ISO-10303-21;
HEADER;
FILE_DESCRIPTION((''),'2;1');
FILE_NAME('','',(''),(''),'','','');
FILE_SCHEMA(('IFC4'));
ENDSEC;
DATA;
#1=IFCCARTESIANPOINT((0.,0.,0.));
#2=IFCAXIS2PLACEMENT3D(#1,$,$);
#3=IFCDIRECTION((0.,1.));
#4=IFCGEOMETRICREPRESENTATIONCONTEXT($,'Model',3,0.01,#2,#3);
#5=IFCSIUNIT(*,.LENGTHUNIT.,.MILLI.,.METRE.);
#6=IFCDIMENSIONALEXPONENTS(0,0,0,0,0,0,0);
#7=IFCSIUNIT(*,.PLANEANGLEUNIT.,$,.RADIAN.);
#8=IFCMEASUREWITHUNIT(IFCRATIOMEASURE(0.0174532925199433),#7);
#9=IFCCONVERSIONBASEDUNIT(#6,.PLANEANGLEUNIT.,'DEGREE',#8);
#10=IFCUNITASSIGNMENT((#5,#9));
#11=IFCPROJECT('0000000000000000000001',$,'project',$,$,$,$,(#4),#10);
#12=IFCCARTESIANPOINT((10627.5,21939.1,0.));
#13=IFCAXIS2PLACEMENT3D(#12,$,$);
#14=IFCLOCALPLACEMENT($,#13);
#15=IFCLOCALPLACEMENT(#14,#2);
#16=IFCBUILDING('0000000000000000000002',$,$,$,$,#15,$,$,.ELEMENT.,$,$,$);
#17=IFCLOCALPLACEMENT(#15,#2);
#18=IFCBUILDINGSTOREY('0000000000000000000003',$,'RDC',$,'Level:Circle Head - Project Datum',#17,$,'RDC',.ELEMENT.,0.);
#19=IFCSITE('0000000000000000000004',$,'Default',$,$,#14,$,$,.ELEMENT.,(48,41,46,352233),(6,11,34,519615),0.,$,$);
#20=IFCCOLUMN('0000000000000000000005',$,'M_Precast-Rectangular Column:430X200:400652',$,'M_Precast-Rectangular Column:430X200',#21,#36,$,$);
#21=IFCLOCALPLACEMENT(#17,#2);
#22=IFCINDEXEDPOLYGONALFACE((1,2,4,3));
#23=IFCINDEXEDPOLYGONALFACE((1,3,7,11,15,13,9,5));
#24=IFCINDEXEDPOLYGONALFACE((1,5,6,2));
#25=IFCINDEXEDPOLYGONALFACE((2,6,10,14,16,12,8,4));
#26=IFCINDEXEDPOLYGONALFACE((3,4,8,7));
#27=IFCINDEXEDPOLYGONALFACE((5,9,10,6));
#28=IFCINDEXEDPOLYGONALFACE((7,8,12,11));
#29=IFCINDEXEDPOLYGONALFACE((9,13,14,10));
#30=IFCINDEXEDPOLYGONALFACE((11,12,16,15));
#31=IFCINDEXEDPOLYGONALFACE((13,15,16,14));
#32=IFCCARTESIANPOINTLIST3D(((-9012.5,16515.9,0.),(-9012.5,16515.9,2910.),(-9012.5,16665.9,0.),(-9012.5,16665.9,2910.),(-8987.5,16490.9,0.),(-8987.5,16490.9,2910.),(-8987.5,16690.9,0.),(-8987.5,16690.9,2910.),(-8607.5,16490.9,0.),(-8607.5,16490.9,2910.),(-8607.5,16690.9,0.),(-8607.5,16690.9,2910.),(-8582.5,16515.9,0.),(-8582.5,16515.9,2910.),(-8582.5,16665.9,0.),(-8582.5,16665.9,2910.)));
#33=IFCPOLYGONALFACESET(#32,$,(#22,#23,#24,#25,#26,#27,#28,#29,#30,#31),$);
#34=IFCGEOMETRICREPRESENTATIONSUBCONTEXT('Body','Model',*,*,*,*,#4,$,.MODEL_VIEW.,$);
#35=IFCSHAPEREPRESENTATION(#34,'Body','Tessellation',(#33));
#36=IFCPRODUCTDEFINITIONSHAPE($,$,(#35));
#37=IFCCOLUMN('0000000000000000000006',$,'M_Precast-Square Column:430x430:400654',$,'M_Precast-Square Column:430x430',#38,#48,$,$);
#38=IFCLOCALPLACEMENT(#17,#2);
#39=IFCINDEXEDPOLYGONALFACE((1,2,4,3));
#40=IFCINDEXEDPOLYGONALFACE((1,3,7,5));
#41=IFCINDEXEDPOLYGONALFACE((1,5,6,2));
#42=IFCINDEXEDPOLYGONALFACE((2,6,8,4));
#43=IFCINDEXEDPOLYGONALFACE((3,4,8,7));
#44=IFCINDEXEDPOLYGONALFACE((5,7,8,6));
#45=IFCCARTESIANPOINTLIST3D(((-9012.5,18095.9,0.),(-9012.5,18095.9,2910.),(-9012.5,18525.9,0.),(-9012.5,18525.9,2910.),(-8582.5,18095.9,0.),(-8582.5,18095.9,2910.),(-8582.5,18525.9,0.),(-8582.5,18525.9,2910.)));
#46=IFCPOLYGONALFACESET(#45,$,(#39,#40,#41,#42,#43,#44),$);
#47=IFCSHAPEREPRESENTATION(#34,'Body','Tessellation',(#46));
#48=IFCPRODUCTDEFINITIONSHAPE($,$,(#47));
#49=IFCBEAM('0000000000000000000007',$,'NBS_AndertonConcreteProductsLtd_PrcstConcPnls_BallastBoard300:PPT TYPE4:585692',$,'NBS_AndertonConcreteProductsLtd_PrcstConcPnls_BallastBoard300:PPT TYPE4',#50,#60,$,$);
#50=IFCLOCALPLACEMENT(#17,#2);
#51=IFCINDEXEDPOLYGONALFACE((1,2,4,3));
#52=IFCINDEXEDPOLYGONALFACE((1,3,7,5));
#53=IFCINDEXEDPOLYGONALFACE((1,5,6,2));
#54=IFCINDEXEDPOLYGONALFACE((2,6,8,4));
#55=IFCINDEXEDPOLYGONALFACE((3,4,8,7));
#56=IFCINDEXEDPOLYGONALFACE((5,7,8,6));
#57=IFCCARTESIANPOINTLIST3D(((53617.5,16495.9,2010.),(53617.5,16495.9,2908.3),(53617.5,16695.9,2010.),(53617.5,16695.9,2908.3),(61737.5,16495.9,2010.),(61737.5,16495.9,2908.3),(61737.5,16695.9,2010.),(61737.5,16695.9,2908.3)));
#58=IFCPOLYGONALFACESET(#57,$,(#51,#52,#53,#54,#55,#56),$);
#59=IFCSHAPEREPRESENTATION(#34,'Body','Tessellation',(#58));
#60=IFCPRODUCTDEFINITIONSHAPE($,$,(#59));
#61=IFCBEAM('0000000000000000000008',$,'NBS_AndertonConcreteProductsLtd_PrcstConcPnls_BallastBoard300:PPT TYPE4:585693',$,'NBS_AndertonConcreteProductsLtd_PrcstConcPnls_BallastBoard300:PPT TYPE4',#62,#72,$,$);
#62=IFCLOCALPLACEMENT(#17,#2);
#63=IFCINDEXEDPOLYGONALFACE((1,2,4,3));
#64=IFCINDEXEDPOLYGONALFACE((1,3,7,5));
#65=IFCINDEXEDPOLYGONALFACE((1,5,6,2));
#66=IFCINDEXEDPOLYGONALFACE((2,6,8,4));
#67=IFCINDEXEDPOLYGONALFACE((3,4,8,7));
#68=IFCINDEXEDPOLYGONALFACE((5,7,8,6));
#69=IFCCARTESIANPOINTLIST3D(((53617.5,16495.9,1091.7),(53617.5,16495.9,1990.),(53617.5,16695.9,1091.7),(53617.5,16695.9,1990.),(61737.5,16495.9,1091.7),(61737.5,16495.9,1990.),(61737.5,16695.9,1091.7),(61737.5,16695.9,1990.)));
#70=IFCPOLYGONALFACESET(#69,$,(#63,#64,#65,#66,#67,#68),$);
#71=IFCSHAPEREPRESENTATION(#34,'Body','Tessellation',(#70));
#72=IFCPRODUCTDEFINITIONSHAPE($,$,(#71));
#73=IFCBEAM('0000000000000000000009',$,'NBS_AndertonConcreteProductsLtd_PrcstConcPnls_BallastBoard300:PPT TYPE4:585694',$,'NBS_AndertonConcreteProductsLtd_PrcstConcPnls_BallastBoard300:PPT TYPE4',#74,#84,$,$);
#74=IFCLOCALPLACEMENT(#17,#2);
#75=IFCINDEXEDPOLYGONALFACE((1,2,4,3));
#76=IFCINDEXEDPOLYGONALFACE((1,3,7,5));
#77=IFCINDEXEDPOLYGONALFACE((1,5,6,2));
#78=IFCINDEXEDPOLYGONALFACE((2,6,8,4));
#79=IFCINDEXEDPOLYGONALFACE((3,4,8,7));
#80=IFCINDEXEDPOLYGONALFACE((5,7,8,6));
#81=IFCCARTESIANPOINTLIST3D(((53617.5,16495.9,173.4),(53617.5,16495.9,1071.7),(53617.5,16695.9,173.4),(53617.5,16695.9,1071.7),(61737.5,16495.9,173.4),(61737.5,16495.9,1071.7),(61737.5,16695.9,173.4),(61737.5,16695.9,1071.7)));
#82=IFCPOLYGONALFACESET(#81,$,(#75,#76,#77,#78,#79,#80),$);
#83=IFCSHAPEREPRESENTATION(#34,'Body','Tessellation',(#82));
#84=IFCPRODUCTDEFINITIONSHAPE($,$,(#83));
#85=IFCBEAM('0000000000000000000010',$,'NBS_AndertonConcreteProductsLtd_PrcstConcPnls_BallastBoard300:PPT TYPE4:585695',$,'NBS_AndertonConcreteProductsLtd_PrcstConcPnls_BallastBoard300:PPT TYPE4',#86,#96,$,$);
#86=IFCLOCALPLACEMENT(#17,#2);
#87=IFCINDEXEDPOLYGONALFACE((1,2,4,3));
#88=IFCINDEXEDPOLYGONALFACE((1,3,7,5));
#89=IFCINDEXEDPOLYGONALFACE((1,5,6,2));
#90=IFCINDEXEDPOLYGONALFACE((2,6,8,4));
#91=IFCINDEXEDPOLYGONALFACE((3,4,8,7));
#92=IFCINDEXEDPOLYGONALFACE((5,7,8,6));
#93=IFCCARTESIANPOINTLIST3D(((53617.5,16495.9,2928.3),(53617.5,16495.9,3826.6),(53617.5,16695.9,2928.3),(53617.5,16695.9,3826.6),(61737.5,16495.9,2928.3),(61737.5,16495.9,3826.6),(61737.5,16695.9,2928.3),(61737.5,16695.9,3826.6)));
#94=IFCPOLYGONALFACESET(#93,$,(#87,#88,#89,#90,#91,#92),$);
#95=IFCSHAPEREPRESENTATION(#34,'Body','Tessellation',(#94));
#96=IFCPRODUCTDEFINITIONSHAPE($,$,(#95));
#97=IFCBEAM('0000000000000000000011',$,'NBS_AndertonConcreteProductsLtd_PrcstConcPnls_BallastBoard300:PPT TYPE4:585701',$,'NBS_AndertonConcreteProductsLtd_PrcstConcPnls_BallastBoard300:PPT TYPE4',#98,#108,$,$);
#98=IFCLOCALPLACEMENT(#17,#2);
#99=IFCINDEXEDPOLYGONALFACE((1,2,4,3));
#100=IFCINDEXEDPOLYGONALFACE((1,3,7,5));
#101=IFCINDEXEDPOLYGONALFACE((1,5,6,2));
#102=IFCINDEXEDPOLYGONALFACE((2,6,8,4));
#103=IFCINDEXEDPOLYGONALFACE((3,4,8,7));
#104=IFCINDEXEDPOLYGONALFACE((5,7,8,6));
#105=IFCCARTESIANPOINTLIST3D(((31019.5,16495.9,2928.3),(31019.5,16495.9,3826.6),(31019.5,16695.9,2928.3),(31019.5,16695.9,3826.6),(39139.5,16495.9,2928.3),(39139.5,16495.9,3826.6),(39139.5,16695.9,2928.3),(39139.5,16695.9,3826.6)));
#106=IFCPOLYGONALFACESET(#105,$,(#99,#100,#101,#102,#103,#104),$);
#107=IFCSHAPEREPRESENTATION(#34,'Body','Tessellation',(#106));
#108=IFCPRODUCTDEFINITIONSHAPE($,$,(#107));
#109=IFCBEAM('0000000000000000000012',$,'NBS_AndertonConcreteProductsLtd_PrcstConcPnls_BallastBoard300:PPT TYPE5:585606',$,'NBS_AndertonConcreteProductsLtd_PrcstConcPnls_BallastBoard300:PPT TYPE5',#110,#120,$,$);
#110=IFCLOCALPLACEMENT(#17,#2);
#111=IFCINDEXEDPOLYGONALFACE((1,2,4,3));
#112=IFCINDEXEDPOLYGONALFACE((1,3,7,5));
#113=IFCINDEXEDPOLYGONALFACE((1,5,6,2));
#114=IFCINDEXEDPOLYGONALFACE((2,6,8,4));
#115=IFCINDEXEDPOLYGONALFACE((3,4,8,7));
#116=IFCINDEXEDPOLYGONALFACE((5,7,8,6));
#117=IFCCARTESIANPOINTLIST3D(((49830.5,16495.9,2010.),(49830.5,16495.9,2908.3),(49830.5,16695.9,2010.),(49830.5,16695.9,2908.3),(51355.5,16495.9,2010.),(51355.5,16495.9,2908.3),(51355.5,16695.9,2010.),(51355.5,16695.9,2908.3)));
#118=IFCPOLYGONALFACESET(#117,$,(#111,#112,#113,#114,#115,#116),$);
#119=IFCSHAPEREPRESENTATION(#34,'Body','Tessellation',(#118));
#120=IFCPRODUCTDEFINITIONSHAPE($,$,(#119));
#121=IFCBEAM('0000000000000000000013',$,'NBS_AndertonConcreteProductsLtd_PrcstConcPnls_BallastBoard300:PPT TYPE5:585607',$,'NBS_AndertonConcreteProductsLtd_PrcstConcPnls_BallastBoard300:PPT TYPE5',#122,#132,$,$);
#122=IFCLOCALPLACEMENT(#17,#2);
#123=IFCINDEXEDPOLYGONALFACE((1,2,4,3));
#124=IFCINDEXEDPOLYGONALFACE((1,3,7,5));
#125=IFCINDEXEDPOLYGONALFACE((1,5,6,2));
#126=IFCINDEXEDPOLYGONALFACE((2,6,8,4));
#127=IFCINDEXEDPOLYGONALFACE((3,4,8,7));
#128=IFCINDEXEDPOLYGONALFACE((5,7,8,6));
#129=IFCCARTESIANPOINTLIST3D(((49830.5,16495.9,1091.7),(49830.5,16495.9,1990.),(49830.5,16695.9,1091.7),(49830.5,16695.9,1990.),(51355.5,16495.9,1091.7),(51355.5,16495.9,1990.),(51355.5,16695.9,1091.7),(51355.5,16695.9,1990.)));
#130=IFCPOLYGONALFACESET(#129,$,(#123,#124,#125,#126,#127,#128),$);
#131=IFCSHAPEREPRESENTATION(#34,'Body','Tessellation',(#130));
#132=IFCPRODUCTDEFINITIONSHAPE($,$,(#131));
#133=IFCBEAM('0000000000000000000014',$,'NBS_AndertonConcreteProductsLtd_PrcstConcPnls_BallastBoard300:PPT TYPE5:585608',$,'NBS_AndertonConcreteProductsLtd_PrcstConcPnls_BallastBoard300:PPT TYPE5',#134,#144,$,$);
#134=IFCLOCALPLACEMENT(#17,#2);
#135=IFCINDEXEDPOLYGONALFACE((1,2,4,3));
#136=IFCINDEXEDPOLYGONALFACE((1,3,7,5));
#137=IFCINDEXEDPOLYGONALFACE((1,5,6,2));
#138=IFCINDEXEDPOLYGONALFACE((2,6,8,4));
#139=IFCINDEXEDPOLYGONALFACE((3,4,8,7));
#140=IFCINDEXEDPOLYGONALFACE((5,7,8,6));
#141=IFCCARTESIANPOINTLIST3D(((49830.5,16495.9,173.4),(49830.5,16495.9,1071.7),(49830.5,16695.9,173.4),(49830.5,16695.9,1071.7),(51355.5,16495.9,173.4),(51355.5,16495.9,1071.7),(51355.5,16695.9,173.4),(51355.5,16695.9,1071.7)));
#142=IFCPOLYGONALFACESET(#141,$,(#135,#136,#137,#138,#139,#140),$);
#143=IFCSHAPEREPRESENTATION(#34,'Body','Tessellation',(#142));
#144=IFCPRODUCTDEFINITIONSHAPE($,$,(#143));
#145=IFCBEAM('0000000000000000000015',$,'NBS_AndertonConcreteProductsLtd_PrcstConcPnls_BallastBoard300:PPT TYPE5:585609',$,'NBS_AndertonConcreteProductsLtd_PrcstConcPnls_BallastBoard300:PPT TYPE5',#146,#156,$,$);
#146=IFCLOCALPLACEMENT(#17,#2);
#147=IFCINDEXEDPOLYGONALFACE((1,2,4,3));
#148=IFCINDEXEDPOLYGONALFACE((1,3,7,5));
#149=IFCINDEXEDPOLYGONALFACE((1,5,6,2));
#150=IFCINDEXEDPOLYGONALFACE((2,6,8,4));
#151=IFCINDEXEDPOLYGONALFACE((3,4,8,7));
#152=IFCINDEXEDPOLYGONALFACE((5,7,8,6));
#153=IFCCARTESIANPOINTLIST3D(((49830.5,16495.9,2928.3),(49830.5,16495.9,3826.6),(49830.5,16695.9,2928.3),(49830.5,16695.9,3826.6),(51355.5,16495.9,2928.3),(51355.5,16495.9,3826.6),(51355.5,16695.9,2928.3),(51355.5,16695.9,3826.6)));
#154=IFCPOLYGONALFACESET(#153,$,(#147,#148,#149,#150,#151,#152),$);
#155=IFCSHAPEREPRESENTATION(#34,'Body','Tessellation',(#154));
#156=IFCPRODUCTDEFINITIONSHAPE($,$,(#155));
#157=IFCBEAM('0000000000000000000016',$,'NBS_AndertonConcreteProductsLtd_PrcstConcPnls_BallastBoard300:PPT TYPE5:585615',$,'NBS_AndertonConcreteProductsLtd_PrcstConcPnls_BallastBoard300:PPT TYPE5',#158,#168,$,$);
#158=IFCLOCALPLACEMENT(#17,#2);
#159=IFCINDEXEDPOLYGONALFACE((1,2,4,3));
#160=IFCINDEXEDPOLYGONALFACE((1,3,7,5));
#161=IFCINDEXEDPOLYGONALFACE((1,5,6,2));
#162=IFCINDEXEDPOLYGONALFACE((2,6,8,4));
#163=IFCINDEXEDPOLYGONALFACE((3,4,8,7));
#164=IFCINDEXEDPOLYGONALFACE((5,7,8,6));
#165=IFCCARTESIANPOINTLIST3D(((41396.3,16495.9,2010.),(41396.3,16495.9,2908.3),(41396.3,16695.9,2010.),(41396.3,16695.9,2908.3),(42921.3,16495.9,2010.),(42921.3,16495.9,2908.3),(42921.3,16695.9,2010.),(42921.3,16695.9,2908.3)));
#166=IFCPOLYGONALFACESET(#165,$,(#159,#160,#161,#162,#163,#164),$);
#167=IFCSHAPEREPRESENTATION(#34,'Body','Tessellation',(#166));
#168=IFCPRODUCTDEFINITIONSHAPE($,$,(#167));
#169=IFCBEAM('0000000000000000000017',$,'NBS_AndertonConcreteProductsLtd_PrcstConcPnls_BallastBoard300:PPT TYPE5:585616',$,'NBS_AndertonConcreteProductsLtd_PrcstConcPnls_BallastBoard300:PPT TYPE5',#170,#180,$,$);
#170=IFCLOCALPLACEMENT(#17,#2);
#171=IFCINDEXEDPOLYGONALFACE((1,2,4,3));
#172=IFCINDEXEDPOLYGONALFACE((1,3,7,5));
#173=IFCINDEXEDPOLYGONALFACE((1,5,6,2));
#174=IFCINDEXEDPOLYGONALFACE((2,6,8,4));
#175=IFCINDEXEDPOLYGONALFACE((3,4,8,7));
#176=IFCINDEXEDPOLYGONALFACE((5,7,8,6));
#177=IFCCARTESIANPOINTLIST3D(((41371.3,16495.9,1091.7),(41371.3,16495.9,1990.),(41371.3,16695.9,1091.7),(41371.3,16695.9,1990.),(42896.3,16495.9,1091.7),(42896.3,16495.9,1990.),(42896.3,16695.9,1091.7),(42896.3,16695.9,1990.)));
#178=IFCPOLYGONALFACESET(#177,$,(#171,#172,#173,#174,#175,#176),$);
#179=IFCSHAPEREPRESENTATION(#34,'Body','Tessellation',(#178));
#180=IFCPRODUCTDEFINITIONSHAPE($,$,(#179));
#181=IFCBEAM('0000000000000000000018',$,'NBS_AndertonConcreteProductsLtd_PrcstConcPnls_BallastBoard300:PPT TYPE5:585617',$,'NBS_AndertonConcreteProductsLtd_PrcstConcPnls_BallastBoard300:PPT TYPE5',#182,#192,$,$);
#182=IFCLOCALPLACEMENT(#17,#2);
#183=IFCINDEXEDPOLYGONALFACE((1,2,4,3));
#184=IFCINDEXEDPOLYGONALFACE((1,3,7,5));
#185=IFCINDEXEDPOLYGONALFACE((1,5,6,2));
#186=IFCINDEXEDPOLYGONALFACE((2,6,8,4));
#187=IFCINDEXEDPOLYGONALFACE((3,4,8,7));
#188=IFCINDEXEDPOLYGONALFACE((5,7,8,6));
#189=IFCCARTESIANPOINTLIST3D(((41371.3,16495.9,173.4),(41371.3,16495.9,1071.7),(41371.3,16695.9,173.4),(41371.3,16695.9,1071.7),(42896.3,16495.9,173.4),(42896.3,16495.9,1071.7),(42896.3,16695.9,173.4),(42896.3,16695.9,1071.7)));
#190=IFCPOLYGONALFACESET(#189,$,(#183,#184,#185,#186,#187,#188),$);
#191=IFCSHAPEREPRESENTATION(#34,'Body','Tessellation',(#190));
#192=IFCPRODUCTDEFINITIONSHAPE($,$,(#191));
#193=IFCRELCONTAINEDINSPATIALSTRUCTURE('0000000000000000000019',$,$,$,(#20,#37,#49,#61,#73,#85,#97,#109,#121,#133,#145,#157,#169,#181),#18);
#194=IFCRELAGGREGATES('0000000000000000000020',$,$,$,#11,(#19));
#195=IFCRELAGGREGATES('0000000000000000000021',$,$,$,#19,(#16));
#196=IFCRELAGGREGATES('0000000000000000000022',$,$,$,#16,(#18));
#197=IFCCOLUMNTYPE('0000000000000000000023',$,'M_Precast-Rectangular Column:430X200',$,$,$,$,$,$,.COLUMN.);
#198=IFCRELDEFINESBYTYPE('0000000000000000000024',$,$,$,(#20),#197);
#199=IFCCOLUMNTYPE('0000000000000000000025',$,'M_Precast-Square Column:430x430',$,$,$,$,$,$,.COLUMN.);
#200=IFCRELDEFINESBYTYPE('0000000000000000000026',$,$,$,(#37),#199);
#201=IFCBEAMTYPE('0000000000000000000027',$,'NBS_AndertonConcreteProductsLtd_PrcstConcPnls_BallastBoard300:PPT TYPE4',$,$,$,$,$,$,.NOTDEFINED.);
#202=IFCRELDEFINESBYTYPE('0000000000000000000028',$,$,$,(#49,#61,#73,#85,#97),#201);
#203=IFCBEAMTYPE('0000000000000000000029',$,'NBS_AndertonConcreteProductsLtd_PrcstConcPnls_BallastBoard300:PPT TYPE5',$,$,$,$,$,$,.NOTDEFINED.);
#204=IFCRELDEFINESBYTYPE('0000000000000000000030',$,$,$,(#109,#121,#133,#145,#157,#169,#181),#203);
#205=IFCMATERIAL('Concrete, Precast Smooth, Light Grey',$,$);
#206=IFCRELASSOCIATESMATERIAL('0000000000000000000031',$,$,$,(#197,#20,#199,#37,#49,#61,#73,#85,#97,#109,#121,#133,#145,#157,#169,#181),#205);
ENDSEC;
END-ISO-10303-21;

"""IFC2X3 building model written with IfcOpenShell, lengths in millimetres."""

from ifc_helpers import new_model, entity, si_unit, converted_unit, direction, frame, frame_2d, origin, origin_2d_with_axis, place, context, subcontext, project, spatial, polyline, rectangle, outline, extrude, source, transform, mapped, material, type_object, type_shapes, element, save


model = new_model("IFC2X3")

# Units and contexts
model_context = context("Model", 3, precision=0.01, world=origin(), true_north=direction((0.0, 1.0)))
body_context = subcontext(model_context, "Body", "Model", "MODEL_VIEW")
ifc_project = project(units=[si_unit("LENGTHUNIT", "METRE", prefix="MILLI"), converted_unit("PLANEANGLEUNIT", "DEGREE", entity("IfcRatioMeasure", 0.0174532925199433), si_unit("PLANEANGLEUNIT", "RADIAN"), dimensions=[0, 0, 0, 0, 0, 0, 0])], contexts=[model_context])

# Site, building, storey
site_placement = place(None, frame((10627.5, 21939.1, 0.0)))
site = spatial("IfcSite", under=ifc_project, at=site_placement, Name="Default", CompositionType="ELEMENT", RefLatitude=(48, 41, 46, 352233), RefLongitude=(6, 11, 34, 519615), RefElevation=0.0)
building_placement = place(site_placement, origin())
building = spatial("IfcBuilding", under=site, at=building_placement, CompositionType="ELEMENT")
storey_placement = place(building_placement, origin())
storey = spatial("IfcBuildingStorey", under=building, at=storey_placement, Name="RDC", ObjectType="Level:Circle Head - Project Datum", LongName="RDC", CompositionType="ELEMENT", Elevation=0.0)

# Columns
ifc_material = material(Name="Concrete, Precast Smooth, Light Grey")
column_type_1 = type_object("IfcColumnType", Name="M_Precast-Rectangular Column:430X200", PredefinedType="COLUMN", material=ifc_material)
shared_shape_1 = source(origin(), body_context, "Body", "SweptSolid", [
    extrude(outline(polyline([(-75.0, -215.0), (75.0, -215.0), (100.0, -190.0), (100.0, 190.0), (75.0, 215.0), (-75.0, 215.0), (-100.0, 190.0), (-100.0, -190.0), (-75.0, -215.0)])), frame((0.0, 0.0, 0.0), z_axis=(0.0, 0.0, 1.0), x_axis=(0.0, -1.0, 0.0)), (0.0, 0.0, 1.0), 2910.0),
])
type_shapes(column_type_1, [shared_shape_1])
column_1_placement = place(storey_placement, frame((-8797.5, 16590.9, 0.0), z_axis=(0.0, 0.0, 1.0), x_axis=(-1.0, 0.0, 0.0)))
element("IfcColumn", 1, at=column_1_placement, inside=storey, type_object=column_type_1, material=ifc_material, Name="M_Precast-Rectangular Column:430X200:400652", ObjectType="M_Precast-Rectangular Column:430X200", context=body_context, shape_type="MappedRepresentation", body=[
    mapped(shared_shape_1, transform((0.0, 0.0, 0.0), scale=1.0)),
])
column_type_2 = type_object("IfcColumnType", Name="M_Precast-Square Column:430x430", PredefinedType="COLUMN", material=ifc_material)
shared_shape_2 = source(origin(), body_context, "Body", "SweptSolid", [
    extrude(rectangle(XDim=430.0, YDim=430.0, at=origin_2d_with_axis()), frame((0.0, 0.0, 0.0), z_axis=(0.0, 0.0, 1.0), x_axis=(0.0, -1.0, 0.0)), (0.0, 0.0, 1.0), 2910.0),
])
type_shapes(column_type_2, [shared_shape_2])
column_2_placement = place(storey_placement, frame((-8797.5, 18310.9, 0.0), z_axis=(0.0, 0.0, 1.0), x_axis=(-1.0, 0.0, 0.0)))
element("IfcColumn", 2, at=column_2_placement, inside=storey, type_object=column_type_2, material=ifc_material, Name="M_Precast-Square Column:430x430:400654", ObjectType="M_Precast-Square Column:430x430", context=body_context, shape_type="MappedRepresentation", body=[
    mapped(shared_shape_2, transform((0.0, 0.0, 0.0), scale=1.0)),
])

# Beams
beam_type_1 = type_object("IfcBeamType", Name="NBS_AndertonConcreteProductsLtd_PrcstConcPnls_BallastBoard300:PPT TYPE4", PredefinedType="NOTDEFINED")
beam_1_placement = place(storey_placement, origin())
element("IfcBeam", 3, at=beam_1_placement, inside=storey, type_object=beam_type_1, material=ifc_material, Name="NBS_AndertonConcreteProductsLtd_PrcstConcPnls_BallastBoard300:PPT TYPE4:585692", ObjectType="NBS_AndertonConcreteProductsLtd_PrcstConcPnls_BallastBoard300:PPT TYPE4", context=body_context, shape_type="SweptSolid", body=[
    extrude(rectangle(XDim=898.3, YDim=200.0, at=frame_2d((0.0, 0.0), x_axis=(1.0, 0.0))), frame((53617.5, 16595.9, 2459.2), z_axis=(1.0, 0.0, 0.0), x_axis=(0.0, 0.0, -1.0)), (0.0, 0.0, 1.0), 8120.0),
])
beam_2_placement = place(storey_placement, origin())
element("IfcBeam", 4, at=beam_2_placement, inside=storey, type_object=beam_type_1, material=ifc_material, Name="NBS_AndertonConcreteProductsLtd_PrcstConcPnls_BallastBoard300:PPT TYPE4:585693", ObjectType="NBS_AndertonConcreteProductsLtd_PrcstConcPnls_BallastBoard300:PPT TYPE4", context=body_context, shape_type="SweptSolid", body=[
    extrude(rectangle(XDim=898.3, YDim=200.0, at=frame_2d((0.0, 0.0), x_axis=(1.0, 0.0))), frame((53617.5, 16595.9, 1540.8), z_axis=(1.0, 0.0, 0.0), x_axis=(0.0, 0.0, -1.0)), (0.0, 0.0, 1.0), 8120.0),
])
beam_3_placement = place(storey_placement, origin())
element("IfcBeam", 5, at=beam_3_placement, inside=storey, type_object=beam_type_1, material=ifc_material, Name="NBS_AndertonConcreteProductsLtd_PrcstConcPnls_BallastBoard300:PPT TYPE4:585694", ObjectType="NBS_AndertonConcreteProductsLtd_PrcstConcPnls_BallastBoard300:PPT TYPE4", context=body_context, shape_type="SweptSolid", body=[
    extrude(rectangle(XDim=898.3, YDim=200.0, at=frame_2d((0.0, 0.0), x_axis=(1.0, 0.0))), frame((53617.5, 16595.9, 622.5), z_axis=(1.0, 0.0, 0.0), x_axis=(0.0, 0.0, -1.0)), (0.0, 0.0, 1.0), 8120.0),
])
beam_4_placement = place(storey_placement, origin())
element("IfcBeam", 6, at=beam_4_placement, inside=storey, type_object=beam_type_1, material=ifc_material, Name="NBS_AndertonConcreteProductsLtd_PrcstConcPnls_BallastBoard300:PPT TYPE4:585695", ObjectType="NBS_AndertonConcreteProductsLtd_PrcstConcPnls_BallastBoard300:PPT TYPE4", context=body_context, shape_type="SweptSolid", body=[
    extrude(rectangle(XDim=898.3, YDim=200.0, at=frame_2d((0.0, 0.0), x_axis=(1.0, 0.0))), frame((53617.5, 16595.9, 3377.5), z_axis=(1.0, 0.0, 0.0), x_axis=(0.0, 0.0, -1.0)), (0.0, 0.0, 1.0), 8120.0),
])
beam_5_placement = place(storey_placement, origin())
element("IfcBeam", 7, at=beam_5_placement, inside=storey, type_object=beam_type_1, material=ifc_material, Name="NBS_AndertonConcreteProductsLtd_PrcstConcPnls_BallastBoard300:PPT TYPE4:585701", ObjectType="NBS_AndertonConcreteProductsLtd_PrcstConcPnls_BallastBoard300:PPT TYPE4", context=body_context, shape_type="SweptSolid", body=[
    extrude(rectangle(XDim=898.3, YDim=200.0, at=frame_2d((0.0, 0.0), x_axis=(1.0, 0.0))), frame((31019.5, 16595.9, 3377.5), z_axis=(1.0, 0.0, 0.0), x_axis=(0.0, 0.0, -1.0)), (0.0, 0.0, 1.0), 8120.0),
])
beam_type_2 = type_object("IfcBeamType", Name="NBS_AndertonConcreteProductsLtd_PrcstConcPnls_BallastBoard300:PPT TYPE5", PredefinedType="NOTDEFINED")
beam_6_placement = place(storey_placement, origin())
element("IfcBeam", 8, at=beam_6_placement, inside=storey, type_object=beam_type_2, material=ifc_material, Name="NBS_AndertonConcreteProductsLtd_PrcstConcPnls_BallastBoard300:PPT TYPE5:585606", ObjectType="NBS_AndertonConcreteProductsLtd_PrcstConcPnls_BallastBoard300:PPT TYPE5", context=body_context, shape_type="SweptSolid", body=[
    extrude(rectangle(XDim=898.3, YDim=200.0, at=frame_2d((0.0, 0.0), x_axis=(1.0, 0.0))), frame((49830.5, 16595.9, 2459.2), z_axis=(1.0, 0.0, 0.0), x_axis=(0.0, 0.0, -1.0)), (0.0, 0.0, 1.0), 1525.0),
])
beam_7_placement = place(storey_placement, origin())
element("IfcBeam", 9, at=beam_7_placement, inside=storey, type_object=beam_type_2, material=ifc_material, Name="NBS_AndertonConcreteProductsLtd_PrcstConcPnls_BallastBoard300:PPT TYPE5:585607", ObjectType="NBS_AndertonConcreteProductsLtd_PrcstConcPnls_BallastBoard300:PPT TYPE5", context=body_context, shape_type="SweptSolid", body=[
    extrude(rectangle(XDim=898.3, YDim=200.0, at=frame_2d((0.0, 0.0), x_axis=(1.0, 0.0))), frame((49830.5, 16595.9, 1540.8), z_axis=(1.0, 0.0, 0.0), x_axis=(0.0, 0.0, -1.0)), (0.0, 0.0, 1.0), 1525.0),
])
beam_8_placement = place(storey_placement, origin())
element("IfcBeam", 10, at=beam_8_placement, inside=storey, type_object=beam_type_2, material=ifc_material, Name="NBS_AndertonConcreteProductsLtd_PrcstConcPnls_BallastBoard300:PPT TYPE5:585608", ObjectType="NBS_AndertonConcreteProductsLtd_PrcstConcPnls_BallastBoard300:PPT TYPE5", context=body_context, shape_type="SweptSolid", body=[
    extrude(rectangle(XDim=898.3, YDim=200.0, at=frame_2d((0.0, 0.0), x_axis=(1.0, 0.0))), frame((49830.5, 16595.9, 622.5), z_axis=(1.0, 0.0, 0.0), x_axis=(0.0, 0.0, -1.0)), (0.0, 0.0, 1.0), 1525.0),
])
beam_9_placement = place(storey_placement, origin())
element("IfcBeam", 11, at=beam_9_placement, inside=storey, type_object=beam_type_2, material=ifc_material, Name="NBS_AndertonConcreteProductsLtd_PrcstConcPnls_BallastBoard300:PPT TYPE5:585609", ObjectType="NBS_AndertonConcreteProductsLtd_PrcstConcPnls_BallastBoard300:PPT TYPE5", context=body_context, shape_type="SweptSolid", body=[
    extrude(rectangle(XDim=898.3, YDim=200.0, at=frame_2d((0.0, 0.0), x_axis=(1.0, 0.0))), frame((49830.5, 16595.9, 3377.5), z_axis=(1.0, 0.0, 0.0), x_axis=(0.0, 0.0, -1.0)), (0.0, 0.0, 1.0), 1525.0),
])
beam_10_placement = place(storey_placement, origin())
element("IfcBeam", 12, at=beam_10_placement, inside=storey, type_object=beam_type_2, material=ifc_material, Name="NBS_AndertonConcreteProductsLtd_PrcstConcPnls_BallastBoard300:PPT TYPE5:585615", ObjectType="NBS_AndertonConcreteProductsLtd_PrcstConcPnls_BallastBoard300:PPT TYPE5", context=body_context, shape_type="SweptSolid", body=[
    extrude(rectangle(XDim=898.3, YDim=200.0, at=frame_2d((0.0, 0.0), x_axis=(1.0, 0.0))), frame((41396.3, 16595.9, 2459.2), z_axis=(1.0, 0.0, 0.0), x_axis=(0.0, 0.0, -1.0)), (0.0, 0.0, 1.0), 1525.0),
])
beam_11_placement = place(storey_placement, origin())
element("IfcBeam", 13, at=beam_11_placement, inside=storey, type_object=beam_type_2, material=ifc_material, Name="NBS_AndertonConcreteProductsLtd_PrcstConcPnls_BallastBoard300:PPT TYPE5:585616", ObjectType="NBS_AndertonConcreteProductsLtd_PrcstConcPnls_BallastBoard300:PPT TYPE5", context=body_context, shape_type="SweptSolid", body=[
    extrude(rectangle(XDim=898.3, YDim=200.0, at=frame_2d((0.0, 0.0), x_axis=(1.0, 0.0))), frame((41371.3, 16595.9, 1540.8), z_axis=(1.0, 0.0, 0.0), x_axis=(0.0, 0.0, -1.0)), (0.0, 0.0, 1.0), 1525.0),
])
beam_12_placement = place(storey_placement, origin())
element("IfcBeam", 14, at=beam_12_placement, inside=storey, type_object=beam_type_2, material=ifc_material, Name="NBS_AndertonConcreteProductsLtd_PrcstConcPnls_BallastBoard300:PPT TYPE5:585617", ObjectType="NBS_AndertonConcreteProductsLtd_PrcstConcPnls_BallastBoard300:PPT TYPE5", context=body_context, shape_type="SweptSolid", body=[
    extrude(rectangle(XDim=898.3, YDim=200.0, at=frame_2d((0.0, 0.0), x_axis=(1.0, 0.0))), frame((41371.3, 16595.9, 622.5), z_axis=(1.0, 0.0, 0.0), x_axis=(0.0, 0.0, -1.0)), (0.0, 0.0, 1.0), 1525.0),
])

save(model, "model.ifc")
